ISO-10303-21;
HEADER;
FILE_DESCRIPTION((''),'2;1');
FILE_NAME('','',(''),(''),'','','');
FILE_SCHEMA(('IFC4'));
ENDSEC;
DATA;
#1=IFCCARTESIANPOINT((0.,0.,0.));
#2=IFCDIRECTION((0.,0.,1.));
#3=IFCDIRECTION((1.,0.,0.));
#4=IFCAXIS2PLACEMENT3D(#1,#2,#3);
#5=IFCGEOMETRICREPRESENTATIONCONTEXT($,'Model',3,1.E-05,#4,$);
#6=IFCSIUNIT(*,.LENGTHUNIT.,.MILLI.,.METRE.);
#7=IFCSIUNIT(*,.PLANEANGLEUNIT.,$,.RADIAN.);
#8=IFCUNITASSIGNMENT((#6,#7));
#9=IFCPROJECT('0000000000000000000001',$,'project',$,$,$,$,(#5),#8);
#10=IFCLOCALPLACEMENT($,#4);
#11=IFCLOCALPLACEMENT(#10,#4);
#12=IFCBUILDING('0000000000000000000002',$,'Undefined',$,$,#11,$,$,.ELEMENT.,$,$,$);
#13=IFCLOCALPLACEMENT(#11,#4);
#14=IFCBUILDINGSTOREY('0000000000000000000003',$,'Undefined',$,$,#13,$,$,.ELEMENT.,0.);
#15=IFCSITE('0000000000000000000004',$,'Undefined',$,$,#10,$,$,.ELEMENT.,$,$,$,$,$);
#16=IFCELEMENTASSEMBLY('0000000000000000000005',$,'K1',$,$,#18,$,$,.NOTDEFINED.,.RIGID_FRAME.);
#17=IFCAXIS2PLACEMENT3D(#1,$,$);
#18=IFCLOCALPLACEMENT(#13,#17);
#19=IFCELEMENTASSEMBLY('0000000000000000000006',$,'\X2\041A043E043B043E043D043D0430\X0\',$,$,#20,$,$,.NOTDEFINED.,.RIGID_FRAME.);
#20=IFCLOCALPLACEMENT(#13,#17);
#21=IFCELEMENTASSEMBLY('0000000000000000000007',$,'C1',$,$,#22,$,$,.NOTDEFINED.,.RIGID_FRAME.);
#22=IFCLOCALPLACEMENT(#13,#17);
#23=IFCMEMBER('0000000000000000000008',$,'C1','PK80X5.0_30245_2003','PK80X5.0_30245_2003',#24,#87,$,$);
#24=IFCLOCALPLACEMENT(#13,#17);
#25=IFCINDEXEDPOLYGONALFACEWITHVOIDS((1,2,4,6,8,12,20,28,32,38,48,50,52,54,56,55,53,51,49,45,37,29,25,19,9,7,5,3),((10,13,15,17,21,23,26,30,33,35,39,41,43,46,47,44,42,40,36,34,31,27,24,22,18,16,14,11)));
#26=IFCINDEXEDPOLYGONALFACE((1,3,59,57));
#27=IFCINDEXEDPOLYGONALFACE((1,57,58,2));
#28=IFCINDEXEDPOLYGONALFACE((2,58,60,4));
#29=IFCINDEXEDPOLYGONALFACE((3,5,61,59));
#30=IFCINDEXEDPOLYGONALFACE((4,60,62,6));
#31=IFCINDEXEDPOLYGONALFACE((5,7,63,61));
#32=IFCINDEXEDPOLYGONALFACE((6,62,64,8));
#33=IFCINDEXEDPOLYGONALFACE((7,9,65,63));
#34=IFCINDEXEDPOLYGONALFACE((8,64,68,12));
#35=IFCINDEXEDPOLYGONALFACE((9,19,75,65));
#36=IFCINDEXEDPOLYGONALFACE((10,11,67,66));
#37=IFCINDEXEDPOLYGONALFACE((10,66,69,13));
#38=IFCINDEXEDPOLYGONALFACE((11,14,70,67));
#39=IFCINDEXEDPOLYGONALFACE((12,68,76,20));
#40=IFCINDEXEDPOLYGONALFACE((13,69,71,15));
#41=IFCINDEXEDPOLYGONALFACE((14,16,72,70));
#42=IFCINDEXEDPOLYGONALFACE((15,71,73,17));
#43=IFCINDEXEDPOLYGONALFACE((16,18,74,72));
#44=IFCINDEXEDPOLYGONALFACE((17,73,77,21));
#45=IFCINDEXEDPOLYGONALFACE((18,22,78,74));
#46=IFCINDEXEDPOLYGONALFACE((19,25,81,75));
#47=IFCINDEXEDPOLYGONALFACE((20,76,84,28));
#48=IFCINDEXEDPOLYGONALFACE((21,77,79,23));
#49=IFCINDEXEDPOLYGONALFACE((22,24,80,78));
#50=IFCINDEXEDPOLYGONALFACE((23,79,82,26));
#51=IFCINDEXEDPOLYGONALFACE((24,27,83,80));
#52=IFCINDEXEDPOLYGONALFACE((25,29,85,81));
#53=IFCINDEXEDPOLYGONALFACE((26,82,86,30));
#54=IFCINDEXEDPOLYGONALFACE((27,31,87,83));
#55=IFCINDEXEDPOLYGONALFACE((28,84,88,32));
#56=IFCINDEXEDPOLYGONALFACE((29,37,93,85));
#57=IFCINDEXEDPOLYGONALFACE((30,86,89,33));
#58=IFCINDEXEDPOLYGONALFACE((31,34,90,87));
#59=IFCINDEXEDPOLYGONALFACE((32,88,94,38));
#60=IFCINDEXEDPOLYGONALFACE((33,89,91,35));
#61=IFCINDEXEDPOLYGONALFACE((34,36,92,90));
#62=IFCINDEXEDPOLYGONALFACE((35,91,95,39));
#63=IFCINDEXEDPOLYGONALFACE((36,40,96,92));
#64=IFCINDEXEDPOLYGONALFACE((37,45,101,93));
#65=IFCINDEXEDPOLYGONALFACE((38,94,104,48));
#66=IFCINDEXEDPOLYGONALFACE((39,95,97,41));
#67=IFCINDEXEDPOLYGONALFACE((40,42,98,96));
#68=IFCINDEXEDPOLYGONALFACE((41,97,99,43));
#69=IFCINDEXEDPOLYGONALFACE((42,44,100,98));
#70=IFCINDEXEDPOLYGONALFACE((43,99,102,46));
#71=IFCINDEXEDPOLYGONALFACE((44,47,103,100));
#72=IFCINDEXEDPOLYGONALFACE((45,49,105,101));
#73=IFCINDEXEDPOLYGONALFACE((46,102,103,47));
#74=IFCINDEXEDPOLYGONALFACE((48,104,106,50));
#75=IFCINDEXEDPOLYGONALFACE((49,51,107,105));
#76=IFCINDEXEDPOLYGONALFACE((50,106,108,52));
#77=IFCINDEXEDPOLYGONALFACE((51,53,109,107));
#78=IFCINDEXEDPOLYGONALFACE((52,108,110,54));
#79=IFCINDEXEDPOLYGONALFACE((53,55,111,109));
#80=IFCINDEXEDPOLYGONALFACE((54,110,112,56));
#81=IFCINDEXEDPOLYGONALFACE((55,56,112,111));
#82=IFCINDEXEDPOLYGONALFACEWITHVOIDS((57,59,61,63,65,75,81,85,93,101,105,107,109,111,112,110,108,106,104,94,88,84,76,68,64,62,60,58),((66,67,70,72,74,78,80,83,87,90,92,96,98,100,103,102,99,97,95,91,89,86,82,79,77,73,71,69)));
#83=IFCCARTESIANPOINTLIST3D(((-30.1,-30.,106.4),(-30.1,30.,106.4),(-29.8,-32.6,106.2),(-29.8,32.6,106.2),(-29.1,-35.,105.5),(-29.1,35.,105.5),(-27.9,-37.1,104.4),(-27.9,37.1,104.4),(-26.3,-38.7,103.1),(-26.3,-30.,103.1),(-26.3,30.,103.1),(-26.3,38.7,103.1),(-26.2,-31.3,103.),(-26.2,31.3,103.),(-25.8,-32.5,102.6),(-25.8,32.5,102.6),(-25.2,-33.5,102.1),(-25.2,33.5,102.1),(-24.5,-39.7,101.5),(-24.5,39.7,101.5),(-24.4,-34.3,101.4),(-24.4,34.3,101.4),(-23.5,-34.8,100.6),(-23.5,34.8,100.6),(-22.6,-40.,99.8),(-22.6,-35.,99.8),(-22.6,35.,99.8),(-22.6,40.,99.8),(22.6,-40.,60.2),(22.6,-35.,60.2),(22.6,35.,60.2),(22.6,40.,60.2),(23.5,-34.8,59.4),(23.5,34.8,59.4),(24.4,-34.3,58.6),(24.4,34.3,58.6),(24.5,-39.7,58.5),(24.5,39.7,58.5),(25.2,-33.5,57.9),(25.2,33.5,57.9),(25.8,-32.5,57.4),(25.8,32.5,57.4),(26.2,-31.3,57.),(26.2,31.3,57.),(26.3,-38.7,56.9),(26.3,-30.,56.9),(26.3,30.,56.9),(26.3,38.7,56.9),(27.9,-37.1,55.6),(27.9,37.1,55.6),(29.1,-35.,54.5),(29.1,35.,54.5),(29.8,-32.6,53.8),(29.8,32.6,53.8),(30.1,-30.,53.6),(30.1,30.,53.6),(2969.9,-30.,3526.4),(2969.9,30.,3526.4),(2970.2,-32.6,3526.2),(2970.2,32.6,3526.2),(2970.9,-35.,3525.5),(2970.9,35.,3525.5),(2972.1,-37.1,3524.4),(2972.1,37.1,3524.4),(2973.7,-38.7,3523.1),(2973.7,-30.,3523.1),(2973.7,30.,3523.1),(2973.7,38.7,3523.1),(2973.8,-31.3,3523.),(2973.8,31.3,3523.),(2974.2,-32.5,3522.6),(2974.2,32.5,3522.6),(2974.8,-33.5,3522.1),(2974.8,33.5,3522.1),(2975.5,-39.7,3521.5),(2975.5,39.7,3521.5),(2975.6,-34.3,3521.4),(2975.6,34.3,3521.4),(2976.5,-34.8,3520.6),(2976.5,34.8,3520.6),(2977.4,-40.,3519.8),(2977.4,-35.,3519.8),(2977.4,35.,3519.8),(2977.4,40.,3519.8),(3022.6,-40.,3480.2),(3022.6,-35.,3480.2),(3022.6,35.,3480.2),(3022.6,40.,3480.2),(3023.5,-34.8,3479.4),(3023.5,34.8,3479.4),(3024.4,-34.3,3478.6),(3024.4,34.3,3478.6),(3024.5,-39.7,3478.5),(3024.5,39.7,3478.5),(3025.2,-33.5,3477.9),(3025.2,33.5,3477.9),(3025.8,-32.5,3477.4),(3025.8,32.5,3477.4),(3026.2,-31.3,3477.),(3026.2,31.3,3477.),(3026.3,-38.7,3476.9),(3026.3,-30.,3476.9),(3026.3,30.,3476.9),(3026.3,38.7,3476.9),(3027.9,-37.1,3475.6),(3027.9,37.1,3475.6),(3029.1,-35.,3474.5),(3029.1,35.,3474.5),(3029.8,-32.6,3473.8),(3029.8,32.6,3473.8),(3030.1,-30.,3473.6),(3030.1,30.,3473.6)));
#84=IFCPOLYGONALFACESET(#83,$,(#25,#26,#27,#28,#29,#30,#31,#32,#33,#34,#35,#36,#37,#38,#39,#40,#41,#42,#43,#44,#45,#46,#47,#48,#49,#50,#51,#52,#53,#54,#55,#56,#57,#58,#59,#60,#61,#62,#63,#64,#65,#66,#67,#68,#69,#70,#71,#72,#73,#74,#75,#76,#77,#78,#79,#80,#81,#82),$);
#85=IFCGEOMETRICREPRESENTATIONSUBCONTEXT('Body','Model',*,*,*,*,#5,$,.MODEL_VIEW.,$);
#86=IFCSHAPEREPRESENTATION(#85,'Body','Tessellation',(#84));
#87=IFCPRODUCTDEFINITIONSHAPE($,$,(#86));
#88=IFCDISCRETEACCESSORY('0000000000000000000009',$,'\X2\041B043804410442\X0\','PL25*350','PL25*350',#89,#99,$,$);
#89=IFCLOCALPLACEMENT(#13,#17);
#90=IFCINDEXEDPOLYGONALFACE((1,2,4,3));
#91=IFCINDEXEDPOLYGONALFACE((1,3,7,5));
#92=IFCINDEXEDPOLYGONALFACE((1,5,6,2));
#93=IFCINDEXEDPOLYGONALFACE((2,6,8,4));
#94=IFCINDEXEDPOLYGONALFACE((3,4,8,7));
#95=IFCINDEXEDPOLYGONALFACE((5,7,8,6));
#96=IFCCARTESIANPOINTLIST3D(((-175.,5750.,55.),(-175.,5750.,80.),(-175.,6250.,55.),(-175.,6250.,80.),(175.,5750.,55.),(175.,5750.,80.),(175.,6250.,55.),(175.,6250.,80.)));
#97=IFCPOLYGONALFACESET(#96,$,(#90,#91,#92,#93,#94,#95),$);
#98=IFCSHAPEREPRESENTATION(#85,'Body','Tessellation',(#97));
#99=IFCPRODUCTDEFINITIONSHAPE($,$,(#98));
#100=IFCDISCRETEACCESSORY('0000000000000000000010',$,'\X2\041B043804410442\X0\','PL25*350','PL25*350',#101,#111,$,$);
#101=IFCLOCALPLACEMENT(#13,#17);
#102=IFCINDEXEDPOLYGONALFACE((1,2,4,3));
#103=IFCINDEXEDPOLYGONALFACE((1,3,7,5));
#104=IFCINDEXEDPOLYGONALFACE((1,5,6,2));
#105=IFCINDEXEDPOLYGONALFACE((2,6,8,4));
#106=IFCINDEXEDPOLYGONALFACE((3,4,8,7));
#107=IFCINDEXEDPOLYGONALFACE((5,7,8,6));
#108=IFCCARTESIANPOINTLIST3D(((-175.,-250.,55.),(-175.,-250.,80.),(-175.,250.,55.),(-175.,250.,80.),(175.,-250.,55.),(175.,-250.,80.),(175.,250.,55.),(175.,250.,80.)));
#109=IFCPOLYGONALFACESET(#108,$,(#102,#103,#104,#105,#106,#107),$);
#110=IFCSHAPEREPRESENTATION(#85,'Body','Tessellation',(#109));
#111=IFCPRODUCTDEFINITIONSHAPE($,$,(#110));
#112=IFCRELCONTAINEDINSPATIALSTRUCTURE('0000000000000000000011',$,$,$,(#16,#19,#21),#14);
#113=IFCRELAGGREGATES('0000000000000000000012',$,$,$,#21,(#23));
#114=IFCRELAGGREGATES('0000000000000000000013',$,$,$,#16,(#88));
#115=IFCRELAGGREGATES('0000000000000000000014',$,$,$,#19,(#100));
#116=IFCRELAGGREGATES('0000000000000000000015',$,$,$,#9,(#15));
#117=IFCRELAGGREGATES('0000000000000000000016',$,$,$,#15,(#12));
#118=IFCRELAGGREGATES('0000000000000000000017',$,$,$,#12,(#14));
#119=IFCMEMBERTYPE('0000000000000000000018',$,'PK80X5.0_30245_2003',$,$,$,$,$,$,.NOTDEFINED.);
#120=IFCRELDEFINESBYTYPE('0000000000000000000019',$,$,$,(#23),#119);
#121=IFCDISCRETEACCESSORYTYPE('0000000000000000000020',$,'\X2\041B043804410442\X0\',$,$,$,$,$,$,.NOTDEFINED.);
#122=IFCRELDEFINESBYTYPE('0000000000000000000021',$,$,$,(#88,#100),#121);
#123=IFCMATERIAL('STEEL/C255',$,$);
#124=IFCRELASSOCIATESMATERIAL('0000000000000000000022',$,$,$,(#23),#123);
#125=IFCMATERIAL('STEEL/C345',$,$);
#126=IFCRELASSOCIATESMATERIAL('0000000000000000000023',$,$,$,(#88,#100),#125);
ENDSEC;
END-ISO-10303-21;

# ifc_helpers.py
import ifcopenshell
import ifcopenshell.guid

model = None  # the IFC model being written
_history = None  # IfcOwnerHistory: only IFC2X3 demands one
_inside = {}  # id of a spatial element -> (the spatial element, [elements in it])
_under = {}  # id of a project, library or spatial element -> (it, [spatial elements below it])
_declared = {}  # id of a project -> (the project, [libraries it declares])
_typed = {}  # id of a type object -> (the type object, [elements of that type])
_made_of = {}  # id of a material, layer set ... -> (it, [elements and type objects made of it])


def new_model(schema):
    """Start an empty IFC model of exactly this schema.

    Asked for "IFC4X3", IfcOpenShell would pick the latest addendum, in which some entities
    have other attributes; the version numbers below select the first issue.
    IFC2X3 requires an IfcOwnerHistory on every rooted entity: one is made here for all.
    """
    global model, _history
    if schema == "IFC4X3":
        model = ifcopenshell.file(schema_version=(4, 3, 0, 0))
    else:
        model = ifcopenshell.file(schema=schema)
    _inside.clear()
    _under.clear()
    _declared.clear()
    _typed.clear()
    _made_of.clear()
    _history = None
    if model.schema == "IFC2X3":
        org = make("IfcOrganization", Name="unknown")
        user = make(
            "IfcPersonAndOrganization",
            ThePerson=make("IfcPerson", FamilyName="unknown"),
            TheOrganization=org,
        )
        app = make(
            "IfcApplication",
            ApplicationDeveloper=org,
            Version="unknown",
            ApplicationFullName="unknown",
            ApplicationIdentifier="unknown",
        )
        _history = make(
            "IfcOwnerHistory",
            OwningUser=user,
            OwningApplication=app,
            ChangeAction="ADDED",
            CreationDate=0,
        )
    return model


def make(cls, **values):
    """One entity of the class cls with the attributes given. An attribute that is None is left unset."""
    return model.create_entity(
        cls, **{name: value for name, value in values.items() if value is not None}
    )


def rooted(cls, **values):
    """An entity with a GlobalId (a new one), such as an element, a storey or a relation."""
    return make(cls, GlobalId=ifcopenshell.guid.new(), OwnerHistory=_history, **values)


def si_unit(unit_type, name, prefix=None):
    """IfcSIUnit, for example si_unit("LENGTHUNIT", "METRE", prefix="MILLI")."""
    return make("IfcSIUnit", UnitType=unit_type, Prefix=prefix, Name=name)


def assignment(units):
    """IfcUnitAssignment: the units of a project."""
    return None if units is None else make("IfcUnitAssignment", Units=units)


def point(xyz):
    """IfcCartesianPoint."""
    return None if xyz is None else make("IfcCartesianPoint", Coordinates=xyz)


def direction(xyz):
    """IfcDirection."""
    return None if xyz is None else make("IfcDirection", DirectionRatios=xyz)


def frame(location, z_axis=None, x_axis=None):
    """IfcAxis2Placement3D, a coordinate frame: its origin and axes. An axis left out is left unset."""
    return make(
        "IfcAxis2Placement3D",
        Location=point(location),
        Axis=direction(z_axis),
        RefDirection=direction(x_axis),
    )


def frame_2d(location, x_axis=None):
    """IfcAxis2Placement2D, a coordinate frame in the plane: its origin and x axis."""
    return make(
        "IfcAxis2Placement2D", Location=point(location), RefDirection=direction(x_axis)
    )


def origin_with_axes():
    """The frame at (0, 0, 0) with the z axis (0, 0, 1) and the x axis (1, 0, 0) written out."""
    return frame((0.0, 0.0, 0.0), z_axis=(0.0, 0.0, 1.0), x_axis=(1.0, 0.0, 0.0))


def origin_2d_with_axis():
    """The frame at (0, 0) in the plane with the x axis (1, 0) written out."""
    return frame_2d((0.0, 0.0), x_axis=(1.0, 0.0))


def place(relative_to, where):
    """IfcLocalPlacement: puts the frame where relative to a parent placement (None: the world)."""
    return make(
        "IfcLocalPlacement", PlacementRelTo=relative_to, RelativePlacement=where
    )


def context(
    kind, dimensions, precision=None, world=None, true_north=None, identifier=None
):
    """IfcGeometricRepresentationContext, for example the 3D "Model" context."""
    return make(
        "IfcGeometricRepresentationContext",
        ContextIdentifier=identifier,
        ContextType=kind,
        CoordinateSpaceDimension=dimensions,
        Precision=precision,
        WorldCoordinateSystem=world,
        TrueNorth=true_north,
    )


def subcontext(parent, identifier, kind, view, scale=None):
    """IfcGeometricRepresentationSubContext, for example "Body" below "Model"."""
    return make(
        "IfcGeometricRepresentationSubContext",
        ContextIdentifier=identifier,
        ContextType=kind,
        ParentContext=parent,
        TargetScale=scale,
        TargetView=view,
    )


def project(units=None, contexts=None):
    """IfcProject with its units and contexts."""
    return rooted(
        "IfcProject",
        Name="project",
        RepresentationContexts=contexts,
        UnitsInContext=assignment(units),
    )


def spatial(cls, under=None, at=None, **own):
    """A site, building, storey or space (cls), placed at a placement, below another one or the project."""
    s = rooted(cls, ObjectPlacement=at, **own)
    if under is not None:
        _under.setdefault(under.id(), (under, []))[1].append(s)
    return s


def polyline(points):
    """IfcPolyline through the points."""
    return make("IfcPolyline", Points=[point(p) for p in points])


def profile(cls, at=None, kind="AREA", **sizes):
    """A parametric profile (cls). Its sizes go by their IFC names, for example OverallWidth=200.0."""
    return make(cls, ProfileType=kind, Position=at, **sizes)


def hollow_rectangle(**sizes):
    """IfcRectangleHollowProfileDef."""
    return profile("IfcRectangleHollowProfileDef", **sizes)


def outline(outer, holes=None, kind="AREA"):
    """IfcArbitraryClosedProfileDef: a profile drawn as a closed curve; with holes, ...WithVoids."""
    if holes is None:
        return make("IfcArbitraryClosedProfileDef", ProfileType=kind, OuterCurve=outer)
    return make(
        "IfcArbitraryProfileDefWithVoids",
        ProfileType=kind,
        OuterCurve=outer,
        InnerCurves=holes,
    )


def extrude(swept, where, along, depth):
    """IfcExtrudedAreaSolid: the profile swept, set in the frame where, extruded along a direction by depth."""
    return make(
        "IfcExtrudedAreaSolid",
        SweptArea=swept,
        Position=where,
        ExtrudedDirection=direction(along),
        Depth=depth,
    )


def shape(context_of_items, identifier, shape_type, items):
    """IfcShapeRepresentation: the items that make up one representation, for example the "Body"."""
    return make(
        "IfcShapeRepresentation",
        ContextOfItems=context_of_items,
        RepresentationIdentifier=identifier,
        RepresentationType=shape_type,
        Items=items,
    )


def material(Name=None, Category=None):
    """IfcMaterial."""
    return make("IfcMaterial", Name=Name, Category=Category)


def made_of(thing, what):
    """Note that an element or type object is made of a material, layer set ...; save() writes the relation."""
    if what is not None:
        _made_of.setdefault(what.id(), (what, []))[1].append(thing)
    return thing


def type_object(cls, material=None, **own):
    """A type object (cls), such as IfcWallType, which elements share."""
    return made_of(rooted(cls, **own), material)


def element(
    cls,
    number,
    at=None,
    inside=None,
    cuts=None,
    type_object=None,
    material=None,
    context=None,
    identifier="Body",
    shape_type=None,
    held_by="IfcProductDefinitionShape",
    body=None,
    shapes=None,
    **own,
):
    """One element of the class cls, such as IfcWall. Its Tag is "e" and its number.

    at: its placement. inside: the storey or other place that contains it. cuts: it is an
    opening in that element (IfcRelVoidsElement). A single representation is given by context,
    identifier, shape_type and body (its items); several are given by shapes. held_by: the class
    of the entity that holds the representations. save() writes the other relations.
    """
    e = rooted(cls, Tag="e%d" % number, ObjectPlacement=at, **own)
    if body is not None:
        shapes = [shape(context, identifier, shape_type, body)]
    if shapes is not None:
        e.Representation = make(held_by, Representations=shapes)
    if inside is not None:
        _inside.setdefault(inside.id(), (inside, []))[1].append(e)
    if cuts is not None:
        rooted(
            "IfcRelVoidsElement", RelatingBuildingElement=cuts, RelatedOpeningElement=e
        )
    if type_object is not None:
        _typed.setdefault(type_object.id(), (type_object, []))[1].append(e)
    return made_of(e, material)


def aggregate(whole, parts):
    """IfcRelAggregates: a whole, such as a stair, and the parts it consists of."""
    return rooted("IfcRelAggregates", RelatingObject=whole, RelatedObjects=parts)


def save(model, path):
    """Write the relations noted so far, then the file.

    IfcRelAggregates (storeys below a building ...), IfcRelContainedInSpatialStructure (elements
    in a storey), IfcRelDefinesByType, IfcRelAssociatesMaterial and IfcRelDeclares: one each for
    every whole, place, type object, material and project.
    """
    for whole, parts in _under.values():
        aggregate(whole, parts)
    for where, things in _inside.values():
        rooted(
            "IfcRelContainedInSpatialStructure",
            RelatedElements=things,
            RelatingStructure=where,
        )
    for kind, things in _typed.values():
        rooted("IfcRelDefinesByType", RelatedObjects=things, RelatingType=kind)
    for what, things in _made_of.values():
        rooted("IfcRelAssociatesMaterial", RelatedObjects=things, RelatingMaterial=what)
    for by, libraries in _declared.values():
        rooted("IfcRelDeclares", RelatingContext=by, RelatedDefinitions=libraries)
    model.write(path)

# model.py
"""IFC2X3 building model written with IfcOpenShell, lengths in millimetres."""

from ifc_helpers import new_model, si_unit, frame, origin_with_axes, origin_2d_with_axis, place, context, subcontext, project, spatial, polyline, hollow_rectangle, outline, extrude, material, type_object, element, aggregate, save


model = new_model("IFC2X3")

# Units and contexts
model_context = context("Model", 3, precision=1e-05, world=origin_with_axes())
body_context = subcontext(model_context, "Body", "Model", "MODEL_VIEW")
ifc_project = project(units=[si_unit("LENGTHUNIT", "METRE", prefix="MILLI"), si_unit("PLANEANGLEUNIT", "RADIAN")], contexts=[model_context])

# Site, building, storey
site_placement = place(None, origin_with_axes())
site = spatial("IfcSite", under=ifc_project, at=site_placement, Name="Undefined", CompositionType="ELEMENT")
building_placement = place(site_placement, origin_with_axes())
building = spatial("IfcBuilding", under=site, at=building_placement, Name="Undefined", CompositionType="ELEMENT")
storey_placement = place(building_placement, origin_with_axes())
storey = spatial("IfcBuildingStorey", under=building, at=storey_placement, Name="Undefined", CompositionType="ELEMENT", Elevation=0.0)

# Element assemblies
assembly_1_placement = place(storey_placement, origin_with_axes())
assembly_1 = element("IfcElementAssembly", 1, at=assembly_1_placement, inside=storey, Name="K1", AssemblyPlace="NOTDEFINED", PredefinedType="RIGID_FRAME")
ifc_material_1 = material(Name="STEEL/C345")
assembly_2_placement = place(storey_placement, origin_with_axes())
assembly_2 = element("IfcElementAssembly", 2, at=assembly_2_placement, inside=storey, Name="Колонна", AssemblyPlace="NOTDEFINED", PredefinedType="RIGID_FRAME")

# Shared definitions
ifc_material_2 = material(Name="STEEL/C255")

# Element assembly, member
member_type = type_object("IfcMemberType", Name="PK80X5.0_30245_2003", PredefinedType="NOTDEFINED")
assembly_3_placement = place(storey_placement, origin_with_axes())
assembly_3 = element("IfcElementAssembly", 3, at=assembly_3_placement, inside=storey, Name="C1", AssemblyPlace="NOTDEFINED", PredefinedType="RIGID_FRAME")
member_1_placement = place(assembly_3_placement, frame((0.0, 0.0, 80.0), z_axis=(0.751759, 0.0, -0.659438), x_axis=(0.659438, 0.0, 0.751759)))
member_1 = element("IfcMember", 4, at=member_1_placement, type_object=member_type, material=ifc_material_2, Name="C1", Description="PK80X5.0_30245_2003", ObjectType="PK80X5.0_30245_2003", context=body_context, shape_type="SweptSolid", body=[
    extrude(hollow_rectangle(XDim=80.0, YDim=80.0, WallThickness=5.0, InnerFilletRadius=5.0, OuterFilletRadius=10.0, at=origin_2d_with_axis()), frame((4549.3, 0.0, 0.0), z_axis=(-1.0, 0.0, 0.0), x_axis=(0.0, -1.0, 0.0)), (0.0, 0.0, 1.0), 4549.3),
])
aggregate(assembly_3, [member_1])

# Discrete accessories
discrete_accessory_type = type_object("IfcDiscreteAccessoryType", Name="Лист")
discrete_accessory_1_placement = place(assembly_1_placement, frame((-175.0, 6250.0, 67.5), z_axis=(0.0, 0.0, 1.0), x_axis=(0.0, -1.0, 0.0)))
discrete_accessory_1 = element("IfcDiscreteAccessory", 5, at=discrete_accessory_1_placement, type_object=discrete_accessory_type, material=ifc_material_1, Name="Лист", Description="PL25*350", ObjectType="PL25*350", context=body_context, shape_type="SweptSolid", body=[
    extrude(outline(polyline([(0.0, 0.0), (500.0, 0.0), (500.0, 350.0), (0.0, 350.0), (0.0, 0.0)])), frame((0.0, 0.0, -12.5), z_axis=(0.0, 0.0, 1.0), x_axis=(1.0, 0.0, 0.0)), (0.0, 0.0, 1.0), 25.0),
])
aggregate(assembly_1, [discrete_accessory_1])
discrete_accessory_2_placement = place(assembly_2_placement, frame((-175.0, 250.0, 67.5), z_axis=(0.0, 0.0, 1.0), x_axis=(0.0, -1.0, 0.0)))
discrete_accessory_2 = element("IfcDiscreteAccessory", 6, at=discrete_accessory_2_placement, type_object=discrete_accessory_type, material=ifc_material_1, Name="Лист", Description="PL25*350", ObjectType="PL25*350", context=body_context, shape_type="SweptSolid", body=[
    extrude(outline(polyline([(0.0, 0.0), (500.0, 0.0), (500.0, 350.0), (0.0, 350.0), (0.0, 0.0)])), frame((0.0, 0.0, -12.5), z_axis=(0.0, 0.0, 1.0), x_axis=(1.0, 0.0, 0.0)), (0.0, 0.0, 1.0), 25.0),
])
aggregate(assembly_2, [discrete_accessory_2])

save(model, "model.ifc")
